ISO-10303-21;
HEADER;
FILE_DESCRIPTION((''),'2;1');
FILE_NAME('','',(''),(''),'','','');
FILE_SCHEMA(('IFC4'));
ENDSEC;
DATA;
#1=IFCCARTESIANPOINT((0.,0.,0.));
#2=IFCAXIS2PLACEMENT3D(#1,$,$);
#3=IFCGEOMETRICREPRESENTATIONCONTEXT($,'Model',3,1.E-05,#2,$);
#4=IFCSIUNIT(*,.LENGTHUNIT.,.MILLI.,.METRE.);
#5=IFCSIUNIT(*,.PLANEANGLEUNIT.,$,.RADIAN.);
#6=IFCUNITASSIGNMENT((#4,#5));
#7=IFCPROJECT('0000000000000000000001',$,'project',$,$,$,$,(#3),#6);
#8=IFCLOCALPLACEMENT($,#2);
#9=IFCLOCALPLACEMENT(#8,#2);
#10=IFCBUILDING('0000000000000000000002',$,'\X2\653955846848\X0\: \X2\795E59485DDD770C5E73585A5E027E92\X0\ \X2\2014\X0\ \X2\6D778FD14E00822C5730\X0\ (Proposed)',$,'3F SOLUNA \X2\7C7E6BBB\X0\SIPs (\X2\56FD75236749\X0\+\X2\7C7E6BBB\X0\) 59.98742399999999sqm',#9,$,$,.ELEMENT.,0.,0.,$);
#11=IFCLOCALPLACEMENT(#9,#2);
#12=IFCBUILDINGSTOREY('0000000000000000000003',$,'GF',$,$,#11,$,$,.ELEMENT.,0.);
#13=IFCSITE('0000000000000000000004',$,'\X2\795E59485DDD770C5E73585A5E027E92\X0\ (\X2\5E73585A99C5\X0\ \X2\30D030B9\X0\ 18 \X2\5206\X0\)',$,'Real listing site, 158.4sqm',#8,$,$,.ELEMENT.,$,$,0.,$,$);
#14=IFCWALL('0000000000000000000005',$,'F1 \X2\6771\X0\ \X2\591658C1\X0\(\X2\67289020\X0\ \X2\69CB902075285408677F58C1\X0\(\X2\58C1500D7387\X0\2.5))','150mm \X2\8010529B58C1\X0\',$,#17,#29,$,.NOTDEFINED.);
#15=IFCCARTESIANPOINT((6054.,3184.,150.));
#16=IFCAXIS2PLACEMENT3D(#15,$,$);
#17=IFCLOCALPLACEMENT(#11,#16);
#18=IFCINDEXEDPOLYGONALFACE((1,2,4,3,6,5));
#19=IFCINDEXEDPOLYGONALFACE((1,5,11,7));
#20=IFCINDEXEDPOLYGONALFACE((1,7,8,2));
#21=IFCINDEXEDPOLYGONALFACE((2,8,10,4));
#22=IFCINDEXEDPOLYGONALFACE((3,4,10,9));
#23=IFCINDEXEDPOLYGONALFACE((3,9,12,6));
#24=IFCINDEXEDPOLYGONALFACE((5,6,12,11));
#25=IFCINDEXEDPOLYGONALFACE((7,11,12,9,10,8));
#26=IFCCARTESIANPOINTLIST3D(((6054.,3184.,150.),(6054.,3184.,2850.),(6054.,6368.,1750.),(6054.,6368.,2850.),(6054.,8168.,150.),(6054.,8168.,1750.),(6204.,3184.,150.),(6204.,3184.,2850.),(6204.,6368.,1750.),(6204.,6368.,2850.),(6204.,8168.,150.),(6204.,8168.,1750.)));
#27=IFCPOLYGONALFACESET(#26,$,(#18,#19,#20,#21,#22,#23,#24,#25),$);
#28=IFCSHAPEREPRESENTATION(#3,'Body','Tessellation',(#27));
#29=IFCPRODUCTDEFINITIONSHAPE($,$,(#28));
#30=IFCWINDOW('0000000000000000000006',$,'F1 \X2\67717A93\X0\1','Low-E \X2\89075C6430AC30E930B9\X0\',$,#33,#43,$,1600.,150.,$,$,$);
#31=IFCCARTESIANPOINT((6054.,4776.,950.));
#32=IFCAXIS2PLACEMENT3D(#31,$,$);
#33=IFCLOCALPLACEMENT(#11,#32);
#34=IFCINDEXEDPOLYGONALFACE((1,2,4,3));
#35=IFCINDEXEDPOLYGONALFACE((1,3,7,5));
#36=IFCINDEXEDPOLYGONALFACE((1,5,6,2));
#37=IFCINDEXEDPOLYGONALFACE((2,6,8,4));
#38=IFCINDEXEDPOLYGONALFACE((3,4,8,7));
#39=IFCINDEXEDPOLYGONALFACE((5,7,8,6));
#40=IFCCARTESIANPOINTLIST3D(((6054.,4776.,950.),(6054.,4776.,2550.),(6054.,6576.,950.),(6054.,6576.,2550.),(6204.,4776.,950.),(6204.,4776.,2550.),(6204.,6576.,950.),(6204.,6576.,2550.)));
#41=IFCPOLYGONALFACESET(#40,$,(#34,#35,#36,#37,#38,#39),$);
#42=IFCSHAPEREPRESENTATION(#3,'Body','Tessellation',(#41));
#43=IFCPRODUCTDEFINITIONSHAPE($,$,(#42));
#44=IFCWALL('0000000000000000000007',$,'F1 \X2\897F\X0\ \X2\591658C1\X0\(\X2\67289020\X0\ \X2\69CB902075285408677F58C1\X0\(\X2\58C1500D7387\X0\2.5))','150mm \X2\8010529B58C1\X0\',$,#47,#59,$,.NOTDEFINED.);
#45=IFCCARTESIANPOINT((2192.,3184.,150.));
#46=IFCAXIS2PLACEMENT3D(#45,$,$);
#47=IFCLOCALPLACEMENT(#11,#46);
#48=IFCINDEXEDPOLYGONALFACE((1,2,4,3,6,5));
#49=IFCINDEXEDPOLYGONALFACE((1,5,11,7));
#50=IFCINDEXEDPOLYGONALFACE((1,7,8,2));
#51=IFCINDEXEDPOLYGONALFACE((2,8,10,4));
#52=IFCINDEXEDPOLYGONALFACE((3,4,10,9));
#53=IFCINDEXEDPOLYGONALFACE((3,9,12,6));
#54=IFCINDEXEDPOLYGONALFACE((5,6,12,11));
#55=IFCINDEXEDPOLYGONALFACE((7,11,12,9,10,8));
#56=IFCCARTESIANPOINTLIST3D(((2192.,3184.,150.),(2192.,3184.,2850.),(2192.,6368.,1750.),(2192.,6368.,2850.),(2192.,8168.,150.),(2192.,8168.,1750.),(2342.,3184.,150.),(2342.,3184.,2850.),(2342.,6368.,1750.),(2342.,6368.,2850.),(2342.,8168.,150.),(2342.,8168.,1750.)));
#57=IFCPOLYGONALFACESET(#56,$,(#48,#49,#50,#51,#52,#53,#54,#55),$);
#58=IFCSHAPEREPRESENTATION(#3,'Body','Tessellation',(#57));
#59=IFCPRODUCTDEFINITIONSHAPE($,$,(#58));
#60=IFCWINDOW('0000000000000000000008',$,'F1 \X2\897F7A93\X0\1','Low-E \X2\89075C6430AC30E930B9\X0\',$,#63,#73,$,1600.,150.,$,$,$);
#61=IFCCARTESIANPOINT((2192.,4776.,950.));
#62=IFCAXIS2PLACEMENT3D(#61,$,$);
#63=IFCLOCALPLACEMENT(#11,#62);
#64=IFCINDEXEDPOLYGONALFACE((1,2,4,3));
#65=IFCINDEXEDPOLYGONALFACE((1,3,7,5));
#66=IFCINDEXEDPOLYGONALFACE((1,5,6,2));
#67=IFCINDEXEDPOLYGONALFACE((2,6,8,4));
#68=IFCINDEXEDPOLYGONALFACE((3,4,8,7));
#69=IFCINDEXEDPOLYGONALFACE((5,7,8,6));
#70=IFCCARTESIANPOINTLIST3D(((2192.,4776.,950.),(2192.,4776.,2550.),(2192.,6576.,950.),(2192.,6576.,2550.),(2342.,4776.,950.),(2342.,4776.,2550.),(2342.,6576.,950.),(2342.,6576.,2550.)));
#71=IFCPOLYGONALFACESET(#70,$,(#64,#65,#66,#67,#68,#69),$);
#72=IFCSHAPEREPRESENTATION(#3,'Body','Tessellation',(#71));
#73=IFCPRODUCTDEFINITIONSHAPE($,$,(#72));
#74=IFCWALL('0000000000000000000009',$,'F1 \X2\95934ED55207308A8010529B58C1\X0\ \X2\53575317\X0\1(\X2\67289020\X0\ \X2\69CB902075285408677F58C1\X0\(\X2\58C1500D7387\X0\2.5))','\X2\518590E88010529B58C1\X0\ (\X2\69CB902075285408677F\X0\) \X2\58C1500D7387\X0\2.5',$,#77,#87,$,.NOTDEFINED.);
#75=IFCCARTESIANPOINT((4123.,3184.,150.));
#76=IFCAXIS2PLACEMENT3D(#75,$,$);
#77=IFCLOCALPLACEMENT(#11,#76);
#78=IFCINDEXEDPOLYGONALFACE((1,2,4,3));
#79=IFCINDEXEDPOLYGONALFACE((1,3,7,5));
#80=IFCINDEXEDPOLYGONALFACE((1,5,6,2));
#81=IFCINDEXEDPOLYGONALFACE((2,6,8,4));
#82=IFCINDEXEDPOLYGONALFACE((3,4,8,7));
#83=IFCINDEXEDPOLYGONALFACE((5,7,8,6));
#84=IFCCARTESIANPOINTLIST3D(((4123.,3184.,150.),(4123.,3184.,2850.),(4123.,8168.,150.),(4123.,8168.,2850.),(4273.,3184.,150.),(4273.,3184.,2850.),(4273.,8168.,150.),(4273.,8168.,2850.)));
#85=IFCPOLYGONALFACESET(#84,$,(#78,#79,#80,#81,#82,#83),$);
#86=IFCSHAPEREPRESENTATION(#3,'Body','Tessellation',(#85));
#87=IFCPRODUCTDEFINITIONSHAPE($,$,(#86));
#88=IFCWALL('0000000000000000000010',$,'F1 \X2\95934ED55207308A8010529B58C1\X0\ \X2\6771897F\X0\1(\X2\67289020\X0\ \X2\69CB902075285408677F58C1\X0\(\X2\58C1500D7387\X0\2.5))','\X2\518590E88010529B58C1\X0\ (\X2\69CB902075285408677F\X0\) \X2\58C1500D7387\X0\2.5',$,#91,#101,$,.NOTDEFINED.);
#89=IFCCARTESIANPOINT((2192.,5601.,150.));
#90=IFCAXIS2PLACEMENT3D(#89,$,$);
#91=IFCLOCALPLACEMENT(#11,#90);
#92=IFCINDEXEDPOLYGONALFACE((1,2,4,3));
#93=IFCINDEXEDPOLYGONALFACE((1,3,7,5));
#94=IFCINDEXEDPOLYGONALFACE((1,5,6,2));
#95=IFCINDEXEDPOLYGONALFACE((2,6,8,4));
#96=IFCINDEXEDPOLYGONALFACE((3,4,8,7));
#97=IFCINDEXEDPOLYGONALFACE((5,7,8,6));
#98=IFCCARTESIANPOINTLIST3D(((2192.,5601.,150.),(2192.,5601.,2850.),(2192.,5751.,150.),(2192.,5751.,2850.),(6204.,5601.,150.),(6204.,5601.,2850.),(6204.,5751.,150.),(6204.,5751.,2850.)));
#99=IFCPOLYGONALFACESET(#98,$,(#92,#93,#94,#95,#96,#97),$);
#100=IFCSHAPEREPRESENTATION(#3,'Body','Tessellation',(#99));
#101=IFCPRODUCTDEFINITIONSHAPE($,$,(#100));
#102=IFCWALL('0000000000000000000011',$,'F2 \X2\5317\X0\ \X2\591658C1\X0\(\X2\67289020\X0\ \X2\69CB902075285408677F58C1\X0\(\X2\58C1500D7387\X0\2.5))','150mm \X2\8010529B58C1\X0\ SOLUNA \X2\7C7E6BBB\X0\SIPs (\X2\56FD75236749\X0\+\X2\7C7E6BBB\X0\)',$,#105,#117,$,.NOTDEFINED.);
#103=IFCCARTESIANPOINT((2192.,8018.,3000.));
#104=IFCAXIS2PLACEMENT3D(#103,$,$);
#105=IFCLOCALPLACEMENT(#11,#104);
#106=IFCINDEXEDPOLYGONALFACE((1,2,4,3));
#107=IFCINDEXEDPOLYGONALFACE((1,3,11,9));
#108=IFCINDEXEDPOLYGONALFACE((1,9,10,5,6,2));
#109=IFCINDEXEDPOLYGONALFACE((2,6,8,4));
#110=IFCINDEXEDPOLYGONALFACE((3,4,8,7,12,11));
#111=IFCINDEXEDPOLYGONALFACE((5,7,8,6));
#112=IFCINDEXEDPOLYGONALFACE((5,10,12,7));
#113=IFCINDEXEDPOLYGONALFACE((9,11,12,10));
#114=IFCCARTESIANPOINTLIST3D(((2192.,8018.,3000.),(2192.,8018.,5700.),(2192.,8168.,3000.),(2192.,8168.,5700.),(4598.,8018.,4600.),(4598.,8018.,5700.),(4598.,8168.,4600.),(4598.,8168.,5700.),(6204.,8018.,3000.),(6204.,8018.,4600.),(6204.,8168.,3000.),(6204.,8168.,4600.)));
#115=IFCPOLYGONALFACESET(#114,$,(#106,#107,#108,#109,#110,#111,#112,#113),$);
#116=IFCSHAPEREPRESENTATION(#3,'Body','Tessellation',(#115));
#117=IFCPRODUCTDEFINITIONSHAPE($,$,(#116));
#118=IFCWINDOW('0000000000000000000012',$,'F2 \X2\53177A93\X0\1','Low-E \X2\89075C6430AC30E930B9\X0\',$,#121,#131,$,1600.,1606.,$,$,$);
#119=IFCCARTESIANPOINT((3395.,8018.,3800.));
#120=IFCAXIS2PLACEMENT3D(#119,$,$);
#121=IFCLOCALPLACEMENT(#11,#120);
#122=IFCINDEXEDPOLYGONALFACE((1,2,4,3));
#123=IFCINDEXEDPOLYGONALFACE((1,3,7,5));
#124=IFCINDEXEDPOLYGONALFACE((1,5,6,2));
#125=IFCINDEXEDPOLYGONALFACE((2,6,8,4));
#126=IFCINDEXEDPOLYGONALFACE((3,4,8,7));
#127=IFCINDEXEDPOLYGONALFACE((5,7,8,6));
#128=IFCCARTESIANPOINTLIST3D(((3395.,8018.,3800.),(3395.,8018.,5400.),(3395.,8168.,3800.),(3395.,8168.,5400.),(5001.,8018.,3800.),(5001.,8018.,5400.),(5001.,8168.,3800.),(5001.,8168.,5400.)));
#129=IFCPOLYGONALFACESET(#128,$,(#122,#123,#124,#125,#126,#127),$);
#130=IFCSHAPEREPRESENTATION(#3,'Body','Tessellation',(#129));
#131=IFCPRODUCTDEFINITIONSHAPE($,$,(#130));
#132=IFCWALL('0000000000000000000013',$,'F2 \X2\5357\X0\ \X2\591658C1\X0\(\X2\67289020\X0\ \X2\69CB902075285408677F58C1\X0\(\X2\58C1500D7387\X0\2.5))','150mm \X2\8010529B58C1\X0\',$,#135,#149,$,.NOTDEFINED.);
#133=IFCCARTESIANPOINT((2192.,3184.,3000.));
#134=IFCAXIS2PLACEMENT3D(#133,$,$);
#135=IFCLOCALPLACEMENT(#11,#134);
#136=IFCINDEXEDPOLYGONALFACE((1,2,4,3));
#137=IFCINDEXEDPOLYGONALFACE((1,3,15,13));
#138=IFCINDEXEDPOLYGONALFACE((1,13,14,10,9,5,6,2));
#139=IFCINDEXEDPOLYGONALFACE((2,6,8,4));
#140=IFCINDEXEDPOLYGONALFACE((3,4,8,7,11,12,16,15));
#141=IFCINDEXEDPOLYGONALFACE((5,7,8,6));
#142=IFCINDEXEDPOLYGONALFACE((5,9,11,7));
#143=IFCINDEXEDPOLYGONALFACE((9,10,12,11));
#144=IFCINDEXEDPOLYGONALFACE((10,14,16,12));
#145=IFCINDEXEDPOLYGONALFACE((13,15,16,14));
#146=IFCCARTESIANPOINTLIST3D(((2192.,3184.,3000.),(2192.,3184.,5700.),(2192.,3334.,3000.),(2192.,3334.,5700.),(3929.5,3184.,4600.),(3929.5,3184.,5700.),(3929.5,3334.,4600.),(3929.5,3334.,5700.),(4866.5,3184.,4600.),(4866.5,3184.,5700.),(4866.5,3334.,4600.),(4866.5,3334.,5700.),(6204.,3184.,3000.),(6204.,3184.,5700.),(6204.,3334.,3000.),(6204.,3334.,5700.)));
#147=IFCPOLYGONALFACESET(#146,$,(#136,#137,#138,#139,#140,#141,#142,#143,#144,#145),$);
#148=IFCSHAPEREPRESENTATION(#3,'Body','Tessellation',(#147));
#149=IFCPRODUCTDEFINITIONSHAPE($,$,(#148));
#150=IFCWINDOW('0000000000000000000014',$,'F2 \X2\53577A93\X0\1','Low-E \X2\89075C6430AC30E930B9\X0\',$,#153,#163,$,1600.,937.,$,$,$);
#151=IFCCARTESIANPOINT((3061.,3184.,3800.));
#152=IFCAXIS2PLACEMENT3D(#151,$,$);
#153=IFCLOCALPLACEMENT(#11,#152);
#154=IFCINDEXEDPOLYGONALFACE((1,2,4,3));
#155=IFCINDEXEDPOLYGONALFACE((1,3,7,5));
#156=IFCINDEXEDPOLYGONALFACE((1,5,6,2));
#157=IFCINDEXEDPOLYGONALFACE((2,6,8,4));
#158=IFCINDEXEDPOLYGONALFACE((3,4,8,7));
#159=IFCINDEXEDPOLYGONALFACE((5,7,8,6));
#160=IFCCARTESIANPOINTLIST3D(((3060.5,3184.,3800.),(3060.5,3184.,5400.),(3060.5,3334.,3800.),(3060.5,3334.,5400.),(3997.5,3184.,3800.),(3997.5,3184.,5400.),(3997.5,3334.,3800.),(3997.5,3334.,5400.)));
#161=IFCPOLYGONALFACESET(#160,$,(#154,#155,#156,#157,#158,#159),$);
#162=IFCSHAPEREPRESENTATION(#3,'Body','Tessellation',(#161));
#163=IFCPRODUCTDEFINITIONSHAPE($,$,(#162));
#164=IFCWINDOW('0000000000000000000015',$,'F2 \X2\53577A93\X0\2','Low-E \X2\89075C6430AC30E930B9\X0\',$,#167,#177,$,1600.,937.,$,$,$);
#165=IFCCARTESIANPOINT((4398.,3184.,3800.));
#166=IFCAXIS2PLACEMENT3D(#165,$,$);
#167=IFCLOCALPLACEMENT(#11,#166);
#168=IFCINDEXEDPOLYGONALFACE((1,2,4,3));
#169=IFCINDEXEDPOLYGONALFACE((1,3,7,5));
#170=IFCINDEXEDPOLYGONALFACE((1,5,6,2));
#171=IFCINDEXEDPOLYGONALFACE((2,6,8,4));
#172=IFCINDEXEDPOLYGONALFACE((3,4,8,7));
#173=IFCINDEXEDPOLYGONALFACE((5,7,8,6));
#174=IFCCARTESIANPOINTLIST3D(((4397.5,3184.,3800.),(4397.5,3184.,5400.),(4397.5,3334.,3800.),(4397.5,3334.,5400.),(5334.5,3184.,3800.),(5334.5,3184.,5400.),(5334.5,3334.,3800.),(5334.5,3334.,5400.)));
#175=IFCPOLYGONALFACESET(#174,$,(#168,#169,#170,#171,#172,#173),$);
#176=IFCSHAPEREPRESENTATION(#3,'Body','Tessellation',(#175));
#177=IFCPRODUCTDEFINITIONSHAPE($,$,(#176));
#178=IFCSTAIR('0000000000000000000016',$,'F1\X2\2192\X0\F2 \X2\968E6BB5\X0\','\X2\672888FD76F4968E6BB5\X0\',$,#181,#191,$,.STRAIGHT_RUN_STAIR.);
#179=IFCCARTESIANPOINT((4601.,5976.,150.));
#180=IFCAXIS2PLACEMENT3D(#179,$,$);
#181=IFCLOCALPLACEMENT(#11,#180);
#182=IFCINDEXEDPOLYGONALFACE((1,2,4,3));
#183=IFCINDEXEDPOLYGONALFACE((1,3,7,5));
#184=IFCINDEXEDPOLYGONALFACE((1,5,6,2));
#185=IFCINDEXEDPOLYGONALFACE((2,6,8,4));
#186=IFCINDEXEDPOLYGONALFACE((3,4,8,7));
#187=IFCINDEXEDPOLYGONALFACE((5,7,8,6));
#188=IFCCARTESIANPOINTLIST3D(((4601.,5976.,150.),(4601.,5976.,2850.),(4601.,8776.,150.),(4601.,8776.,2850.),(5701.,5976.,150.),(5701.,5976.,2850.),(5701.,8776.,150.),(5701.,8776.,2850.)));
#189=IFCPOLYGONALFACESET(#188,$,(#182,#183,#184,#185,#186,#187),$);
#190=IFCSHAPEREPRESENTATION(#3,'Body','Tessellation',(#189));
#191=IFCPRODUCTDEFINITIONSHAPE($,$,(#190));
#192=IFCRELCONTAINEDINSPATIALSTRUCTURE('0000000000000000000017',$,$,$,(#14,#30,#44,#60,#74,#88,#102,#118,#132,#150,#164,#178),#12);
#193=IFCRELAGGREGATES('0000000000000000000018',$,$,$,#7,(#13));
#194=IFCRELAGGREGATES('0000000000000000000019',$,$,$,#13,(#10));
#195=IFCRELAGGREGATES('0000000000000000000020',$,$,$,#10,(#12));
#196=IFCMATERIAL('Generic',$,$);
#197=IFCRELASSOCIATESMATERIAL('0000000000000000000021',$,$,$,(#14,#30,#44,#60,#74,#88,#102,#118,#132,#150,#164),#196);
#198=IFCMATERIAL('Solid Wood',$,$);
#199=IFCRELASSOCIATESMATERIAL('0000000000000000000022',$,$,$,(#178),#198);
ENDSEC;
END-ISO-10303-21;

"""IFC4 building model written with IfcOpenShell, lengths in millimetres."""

from ifc_helpers import new_model, si_unit, frame, frame_2d, origin, place, context, project, spatial, rectangle, extrude, material, element, fill, save


model = new_model("IFC4")

# Units and contexts
model_context = context("Model", 3, precision=1e-05, world=origin())
ifc_project = project(units=[si_unit("LENGTHUNIT", "METRE", prefix="MILLI"), si_unit("PLANEANGLEUNIT", "RADIAN")], contexts=[model_context])

# Site, building, storey
site_placement = place(None, origin())
site = spatial("IfcSite", under=ifc_project, at=site_placement, Name="神奈川県平塚市纒 (平塚駅 バス 18 分)", ObjectType="Real listing site, 158.4sqm", CompositionType="ELEMENT", RefElevation=0.0)
building_placement = place(site_placement, origin())
building = spatial("IfcBuilding", under=site, at=building_placement, Name="改善案: 神奈川県平塚市纒 — 海近一般地 (Proposed)", ObjectType="3F SOLUNA 籾殻SIPs (国産杉+籾殻) 59.98742399999999sqm", CompositionType="ELEMENT", ElevationOfRefHeight=0.0, ElevationOfTerrain=0.0)
storey_placement = place(building_placement, origin())
storey = spatial("IfcBuildingStorey", under=building, at=storey_placement, Name="GF", CompositionType="ELEMENT", Elevation=0.0)

# Shared definitions
ifc_material_1 = material(Name="Generic")

# Shared definitions
ifc_material_2 = material(Name="Solid Wood")

# Walls, openings, windows
wall_1_placement = place(storey_placement, frame((6054.0, 3184.0, 150.0)))
wall_1 = element("IfcWall", 1, at=wall_1_placement, inside=storey, material=ifc_material_1, Name="F1 東 外壁(木造 構造用合板壁(壁倍率2.5))", Description="150mm 耐力壁", PredefinedType="NOTDEFINED", context=model_context, shape_type="SweptSolid", body=[
    extrude(rectangle(XDim=150.0, YDim=4984.0, at=frame_2d((75.0, 2492.0))), frame((6054.0, 3184.0, 150.0)), (0.0, 0.0, 1.0), 2700.0),
])
opening_1_placement = place(storey_placement, frame((6054.0, 4776.0, 950.0)))
opening_1 = element("IfcOpeningElement", 2, at=opening_1_placement, cuts=wall_1, PredefinedType="NOTDEFINED", context=model_context, shape_type="SweptSolid", body=[
    extrude(rectangle(XDim=150.0, YDim=1800.0, at=frame_2d((75.0, 900.0))), frame((6054.0, 4776.0, 950.0)), (0.0, 0.0, 1.0), 1600.0),
])
window_1_placement = place(storey_placement, frame((6054.0, 4776.0, 950.0)))
window_1 = element("IfcWindow", 3, at=window_1_placement, inside=storey, material=ifc_material_1, Name="F1 東窓1", Description="Low-E 複層ガラス", OverallHeight=1600.0, OverallWidth=150.0, context=model_context, shape_type="SweptSolid", body=[
    extrude(rectangle(XDim=150.0, YDim=1800.0, at=frame_2d((75.0, 900.0))), frame((6054.0, 4776.0, 950.0)), (0.0, 0.0, 1.0), 1600.0),
])
fill(opening_1, window_1)
wall_2_placement = place(storey_placement, frame((2192.0, 3184.0, 150.0)))
wall_2 = element("IfcWall", 4, at=wall_2_placement, inside=storey, material=ifc_material_1, Name="F1 西 外壁(木造 構造用合板壁(壁倍率2.5))", Description="150mm 耐力壁", PredefinedType="NOTDEFINED", context=model_context, shape_type="SweptSolid", body=[
    extrude(rectangle(XDim=150.0, YDim=4984.0, at=frame_2d((75.0, 2492.0))), frame((2192.0, 3184.0, 150.0)), (0.0, 0.0, 1.0), 2700.0),
])
opening_2_placement = place(storey_placement, frame((2192.0, 4776.0, 950.0)))
opening_2 = element("IfcOpeningElement", 5, at=opening_2_placement, cuts=wall_2, PredefinedType="NOTDEFINED", context=model_context, shape_type="SweptSolid", body=[
    extrude(rectangle(XDim=150.0, YDim=1800.0, at=frame_2d((75.0, 900.0))), frame((2192.0, 4776.0, 950.0)), (0.0, 0.0, 1.0), 1600.0),
])
window_2_placement = place(storey_placement, frame((2192.0, 4776.0, 950.0)))
window_2 = element("IfcWindow", 6, at=window_2_placement, inside=storey, material=ifc_material_1, Name="F1 西窓1", Description="Low-E 複層ガラス", OverallHeight=1600.0, OverallWidth=150.0, context=model_context, shape_type="SweptSolid", body=[
    extrude(rectangle(XDim=150.0, YDim=1800.0, at=frame_2d((75.0, 900.0))), frame((2192.0, 4776.0, 950.0)), (0.0, 0.0, 1.0), 1600.0),
])
fill(opening_2, window_2)

# Walls
wall_3_placement = place(storey_placement, frame((4123.0, 3184.0, 150.0)))
element("IfcWall", 7, at=wall_3_placement, inside=storey, material=ifc_material_1, Name="F1 間仕切り耐力壁 南北1(木造 構造用合板壁(壁倍率2.5))", Description="内部耐力壁 (構造用合板) 壁倍率2.5", PredefinedType="NOTDEFINED", context=model_context, shape_type="SweptSolid", body=[
    extrude(rectangle(XDim=150.0, YDim=4984.0, at=frame_2d((75.0, 2492.0))), frame((4123.0, 3184.0, 150.0)), (0.0, 0.0, 1.0), 2700.0),
])
wall_4_placement = place(storey_placement, frame((2192.0, 5601.0, 150.0)))
element("IfcWall", 8, at=wall_4_placement, inside=storey, material=ifc_material_1, Name="F1 間仕切り耐力壁 東西1(木造 構造用合板壁(壁倍率2.5))", Description="内部耐力壁 (構造用合板) 壁倍率2.5", PredefinedType="NOTDEFINED", context=model_context, shape_type="SweptSolid", body=[
    extrude(rectangle(XDim=4012.0, YDim=150.0, at=frame_2d((2006.0, 75.0))), frame((2192.0, 5601.0, 150.0)), (0.0, 0.0, 1.0), 2700.0),
])

# Wall, opening, window
wall_5_placement = place(storey_placement, frame((2192.0, 8018.0, 3000.0)))
wall_5 = element("IfcWall", 9, at=wall_5_placement, inside=storey, material=ifc_material_1, Name="F2 北 外壁(木造 構造用合板壁(壁倍率2.5))", Description="150mm 耐力壁 SOLUNA 籾殻SIPs (国産杉+籾殻)", PredefinedType="NOTDEFINED", context=model_context, shape_type="SweptSolid", body=[
    extrude(rectangle(XDim=4012.0, YDim=150.0, at=frame_2d((2006.0, 75.0))), frame((2192.0, 8018.0, 3000.0)), (0.0, 0.0, 1.0), 2700.0),
])
opening_3_placement = place(storey_placement, frame((3395.0, 8018.0, 3800.0)))
opening_3 = element("IfcOpeningElement", 10, at=opening_3_placement, cuts=wall_5, PredefinedType="NOTDEFINED", context=model_context, shape_type="SweptSolid", body=[
    extrude(rectangle(XDim=1606.0, YDim=150.0, at=frame_2d((803.0, 75.0))), frame((3395.0, 8018.0, 3800.0)), (0.0, 0.0, 1.0), 1600.0),
])
window_3_placement = place(storey_placement, frame((3395.0, 8018.0, 3800.0)))
window_3 = element("IfcWindow", 11, at=window_3_placement, inside=storey, material=ifc_material_1, Name="F2 北窓1", Description="Low-E 複層ガラス", OverallHeight=1600.0, OverallWidth=1606.0, context=model_context, shape_type="SweptSolid", body=[
    extrude(rectangle(XDim=1606.0, YDim=150.0, at=frame_2d((803.0, 75.0))), frame((3395.0, 8018.0, 3800.0)), (0.0, 0.0, 1.0), 1600.0),
])
fill(opening_3, window_3)

# Wall, openings, windows
wall_6_placement = place(storey_placement, frame((2192.0, 3184.0, 3000.0)))
wall_6 = element("IfcWall", 12, at=wall_6_placement, inside=storey, material=ifc_material_1, Name="F2 南 外壁(木造 構造用合板壁(壁倍率2.5))", Description="150mm 耐力壁", PredefinedType="NOTDEFINED", context=model_context, shape_type="SweptSolid", body=[
    extrude(rectangle(XDim=4012.0, YDim=150.0, at=frame_2d((2006.0, 75.0))), frame((2192.0, 3184.0, 3000.0)), (0.0, 0.0, 1.0), 2700.0),
])
opening_4_placement = place(storey_placement, frame((3061.0, 3184.0, 3800.0)))
opening_4 = element("IfcOpeningElement", 13, at=opening_4_placement, cuts=wall_6, PredefinedType="NOTDEFINED", context=model_context, shape_type="SweptSolid", body=[
    extrude(rectangle(XDim=937.0, YDim=150.0, at=frame_2d((468.0, 75.0))), frame((3061.0, 3184.0, 3800.0)), (0.0, 0.0, 1.0), 1600.0),
])
opening_5_placement = place(storey_placement, frame((4398.0, 3184.0, 3800.0)))
opening_5 = element("IfcOpeningElement", 14, at=opening_5_placement, cuts=wall_6, PredefinedType="NOTDEFINED", context=model_context, shape_type="SweptSolid", body=[
    extrude(rectangle(XDim=937.0, YDim=150.0, at=frame_2d((468.0, 75.0))), frame((4398.0, 3184.0, 3800.0)), (0.0, 0.0, 1.0), 1600.0),
])
window_4_placement = place(storey_placement, frame((3061.0, 3184.0, 3800.0)))
window_4 = element("IfcWindow", 15, at=window_4_placement, inside=storey, material=ifc_material_1, Name="F2 南窓1", Description="Low-E 複層ガラス", OverallHeight=1600.0, OverallWidth=937.0, context=model_context, shape_type="SweptSolid", body=[
    extrude(rectangle(XDim=937.0, YDim=150.0, at=frame_2d((468.0, 75.0))), frame((3061.0, 3184.0, 3800.0)), (0.0, 0.0, 1.0), 1600.0),
])
fill(opening_4, window_4)
window_5_placement = place(storey_placement, frame((4398.0, 3184.0, 3800.0)))
window_5 = element("IfcWindow", 16, at=window_5_placement, inside=storey, material=ifc_material_1, Name="F2 南窓2", Description="Low-E 複層ガラス", OverallHeight=1600.0, OverallWidth=937.0, context=model_context, shape_type="SweptSolid", body=[
    extrude(rectangle(XDim=937.0, YDim=150.0, at=frame_2d((468.0, 75.0))), frame((4398.0, 3184.0, 3800.0)), (0.0, 0.0, 1.0), 1600.0),
])
fill(opening_5, window_5)

# Stair
stair_placement = place(storey_placement, frame((4601.0, 5976.0, 150.0)))
element("IfcStair", 17, at=stair_placement, inside=storey, material=ifc_material_2, Name="F1→F2 階段", Description="木製直階段", PredefinedType="STRAIGHT_RUN_STAIR", context=model_context, shape_type="SweptSolid", body=[
    extrude(rectangle(XDim=1100.0, YDim=2800.0, at=frame_2d((550.0, 1400.0))), frame((4601.0, 5976.0, 150.0)), (0.0, 0.0, 1.0), 2700.0),
])

save(model, "model.ifc")
